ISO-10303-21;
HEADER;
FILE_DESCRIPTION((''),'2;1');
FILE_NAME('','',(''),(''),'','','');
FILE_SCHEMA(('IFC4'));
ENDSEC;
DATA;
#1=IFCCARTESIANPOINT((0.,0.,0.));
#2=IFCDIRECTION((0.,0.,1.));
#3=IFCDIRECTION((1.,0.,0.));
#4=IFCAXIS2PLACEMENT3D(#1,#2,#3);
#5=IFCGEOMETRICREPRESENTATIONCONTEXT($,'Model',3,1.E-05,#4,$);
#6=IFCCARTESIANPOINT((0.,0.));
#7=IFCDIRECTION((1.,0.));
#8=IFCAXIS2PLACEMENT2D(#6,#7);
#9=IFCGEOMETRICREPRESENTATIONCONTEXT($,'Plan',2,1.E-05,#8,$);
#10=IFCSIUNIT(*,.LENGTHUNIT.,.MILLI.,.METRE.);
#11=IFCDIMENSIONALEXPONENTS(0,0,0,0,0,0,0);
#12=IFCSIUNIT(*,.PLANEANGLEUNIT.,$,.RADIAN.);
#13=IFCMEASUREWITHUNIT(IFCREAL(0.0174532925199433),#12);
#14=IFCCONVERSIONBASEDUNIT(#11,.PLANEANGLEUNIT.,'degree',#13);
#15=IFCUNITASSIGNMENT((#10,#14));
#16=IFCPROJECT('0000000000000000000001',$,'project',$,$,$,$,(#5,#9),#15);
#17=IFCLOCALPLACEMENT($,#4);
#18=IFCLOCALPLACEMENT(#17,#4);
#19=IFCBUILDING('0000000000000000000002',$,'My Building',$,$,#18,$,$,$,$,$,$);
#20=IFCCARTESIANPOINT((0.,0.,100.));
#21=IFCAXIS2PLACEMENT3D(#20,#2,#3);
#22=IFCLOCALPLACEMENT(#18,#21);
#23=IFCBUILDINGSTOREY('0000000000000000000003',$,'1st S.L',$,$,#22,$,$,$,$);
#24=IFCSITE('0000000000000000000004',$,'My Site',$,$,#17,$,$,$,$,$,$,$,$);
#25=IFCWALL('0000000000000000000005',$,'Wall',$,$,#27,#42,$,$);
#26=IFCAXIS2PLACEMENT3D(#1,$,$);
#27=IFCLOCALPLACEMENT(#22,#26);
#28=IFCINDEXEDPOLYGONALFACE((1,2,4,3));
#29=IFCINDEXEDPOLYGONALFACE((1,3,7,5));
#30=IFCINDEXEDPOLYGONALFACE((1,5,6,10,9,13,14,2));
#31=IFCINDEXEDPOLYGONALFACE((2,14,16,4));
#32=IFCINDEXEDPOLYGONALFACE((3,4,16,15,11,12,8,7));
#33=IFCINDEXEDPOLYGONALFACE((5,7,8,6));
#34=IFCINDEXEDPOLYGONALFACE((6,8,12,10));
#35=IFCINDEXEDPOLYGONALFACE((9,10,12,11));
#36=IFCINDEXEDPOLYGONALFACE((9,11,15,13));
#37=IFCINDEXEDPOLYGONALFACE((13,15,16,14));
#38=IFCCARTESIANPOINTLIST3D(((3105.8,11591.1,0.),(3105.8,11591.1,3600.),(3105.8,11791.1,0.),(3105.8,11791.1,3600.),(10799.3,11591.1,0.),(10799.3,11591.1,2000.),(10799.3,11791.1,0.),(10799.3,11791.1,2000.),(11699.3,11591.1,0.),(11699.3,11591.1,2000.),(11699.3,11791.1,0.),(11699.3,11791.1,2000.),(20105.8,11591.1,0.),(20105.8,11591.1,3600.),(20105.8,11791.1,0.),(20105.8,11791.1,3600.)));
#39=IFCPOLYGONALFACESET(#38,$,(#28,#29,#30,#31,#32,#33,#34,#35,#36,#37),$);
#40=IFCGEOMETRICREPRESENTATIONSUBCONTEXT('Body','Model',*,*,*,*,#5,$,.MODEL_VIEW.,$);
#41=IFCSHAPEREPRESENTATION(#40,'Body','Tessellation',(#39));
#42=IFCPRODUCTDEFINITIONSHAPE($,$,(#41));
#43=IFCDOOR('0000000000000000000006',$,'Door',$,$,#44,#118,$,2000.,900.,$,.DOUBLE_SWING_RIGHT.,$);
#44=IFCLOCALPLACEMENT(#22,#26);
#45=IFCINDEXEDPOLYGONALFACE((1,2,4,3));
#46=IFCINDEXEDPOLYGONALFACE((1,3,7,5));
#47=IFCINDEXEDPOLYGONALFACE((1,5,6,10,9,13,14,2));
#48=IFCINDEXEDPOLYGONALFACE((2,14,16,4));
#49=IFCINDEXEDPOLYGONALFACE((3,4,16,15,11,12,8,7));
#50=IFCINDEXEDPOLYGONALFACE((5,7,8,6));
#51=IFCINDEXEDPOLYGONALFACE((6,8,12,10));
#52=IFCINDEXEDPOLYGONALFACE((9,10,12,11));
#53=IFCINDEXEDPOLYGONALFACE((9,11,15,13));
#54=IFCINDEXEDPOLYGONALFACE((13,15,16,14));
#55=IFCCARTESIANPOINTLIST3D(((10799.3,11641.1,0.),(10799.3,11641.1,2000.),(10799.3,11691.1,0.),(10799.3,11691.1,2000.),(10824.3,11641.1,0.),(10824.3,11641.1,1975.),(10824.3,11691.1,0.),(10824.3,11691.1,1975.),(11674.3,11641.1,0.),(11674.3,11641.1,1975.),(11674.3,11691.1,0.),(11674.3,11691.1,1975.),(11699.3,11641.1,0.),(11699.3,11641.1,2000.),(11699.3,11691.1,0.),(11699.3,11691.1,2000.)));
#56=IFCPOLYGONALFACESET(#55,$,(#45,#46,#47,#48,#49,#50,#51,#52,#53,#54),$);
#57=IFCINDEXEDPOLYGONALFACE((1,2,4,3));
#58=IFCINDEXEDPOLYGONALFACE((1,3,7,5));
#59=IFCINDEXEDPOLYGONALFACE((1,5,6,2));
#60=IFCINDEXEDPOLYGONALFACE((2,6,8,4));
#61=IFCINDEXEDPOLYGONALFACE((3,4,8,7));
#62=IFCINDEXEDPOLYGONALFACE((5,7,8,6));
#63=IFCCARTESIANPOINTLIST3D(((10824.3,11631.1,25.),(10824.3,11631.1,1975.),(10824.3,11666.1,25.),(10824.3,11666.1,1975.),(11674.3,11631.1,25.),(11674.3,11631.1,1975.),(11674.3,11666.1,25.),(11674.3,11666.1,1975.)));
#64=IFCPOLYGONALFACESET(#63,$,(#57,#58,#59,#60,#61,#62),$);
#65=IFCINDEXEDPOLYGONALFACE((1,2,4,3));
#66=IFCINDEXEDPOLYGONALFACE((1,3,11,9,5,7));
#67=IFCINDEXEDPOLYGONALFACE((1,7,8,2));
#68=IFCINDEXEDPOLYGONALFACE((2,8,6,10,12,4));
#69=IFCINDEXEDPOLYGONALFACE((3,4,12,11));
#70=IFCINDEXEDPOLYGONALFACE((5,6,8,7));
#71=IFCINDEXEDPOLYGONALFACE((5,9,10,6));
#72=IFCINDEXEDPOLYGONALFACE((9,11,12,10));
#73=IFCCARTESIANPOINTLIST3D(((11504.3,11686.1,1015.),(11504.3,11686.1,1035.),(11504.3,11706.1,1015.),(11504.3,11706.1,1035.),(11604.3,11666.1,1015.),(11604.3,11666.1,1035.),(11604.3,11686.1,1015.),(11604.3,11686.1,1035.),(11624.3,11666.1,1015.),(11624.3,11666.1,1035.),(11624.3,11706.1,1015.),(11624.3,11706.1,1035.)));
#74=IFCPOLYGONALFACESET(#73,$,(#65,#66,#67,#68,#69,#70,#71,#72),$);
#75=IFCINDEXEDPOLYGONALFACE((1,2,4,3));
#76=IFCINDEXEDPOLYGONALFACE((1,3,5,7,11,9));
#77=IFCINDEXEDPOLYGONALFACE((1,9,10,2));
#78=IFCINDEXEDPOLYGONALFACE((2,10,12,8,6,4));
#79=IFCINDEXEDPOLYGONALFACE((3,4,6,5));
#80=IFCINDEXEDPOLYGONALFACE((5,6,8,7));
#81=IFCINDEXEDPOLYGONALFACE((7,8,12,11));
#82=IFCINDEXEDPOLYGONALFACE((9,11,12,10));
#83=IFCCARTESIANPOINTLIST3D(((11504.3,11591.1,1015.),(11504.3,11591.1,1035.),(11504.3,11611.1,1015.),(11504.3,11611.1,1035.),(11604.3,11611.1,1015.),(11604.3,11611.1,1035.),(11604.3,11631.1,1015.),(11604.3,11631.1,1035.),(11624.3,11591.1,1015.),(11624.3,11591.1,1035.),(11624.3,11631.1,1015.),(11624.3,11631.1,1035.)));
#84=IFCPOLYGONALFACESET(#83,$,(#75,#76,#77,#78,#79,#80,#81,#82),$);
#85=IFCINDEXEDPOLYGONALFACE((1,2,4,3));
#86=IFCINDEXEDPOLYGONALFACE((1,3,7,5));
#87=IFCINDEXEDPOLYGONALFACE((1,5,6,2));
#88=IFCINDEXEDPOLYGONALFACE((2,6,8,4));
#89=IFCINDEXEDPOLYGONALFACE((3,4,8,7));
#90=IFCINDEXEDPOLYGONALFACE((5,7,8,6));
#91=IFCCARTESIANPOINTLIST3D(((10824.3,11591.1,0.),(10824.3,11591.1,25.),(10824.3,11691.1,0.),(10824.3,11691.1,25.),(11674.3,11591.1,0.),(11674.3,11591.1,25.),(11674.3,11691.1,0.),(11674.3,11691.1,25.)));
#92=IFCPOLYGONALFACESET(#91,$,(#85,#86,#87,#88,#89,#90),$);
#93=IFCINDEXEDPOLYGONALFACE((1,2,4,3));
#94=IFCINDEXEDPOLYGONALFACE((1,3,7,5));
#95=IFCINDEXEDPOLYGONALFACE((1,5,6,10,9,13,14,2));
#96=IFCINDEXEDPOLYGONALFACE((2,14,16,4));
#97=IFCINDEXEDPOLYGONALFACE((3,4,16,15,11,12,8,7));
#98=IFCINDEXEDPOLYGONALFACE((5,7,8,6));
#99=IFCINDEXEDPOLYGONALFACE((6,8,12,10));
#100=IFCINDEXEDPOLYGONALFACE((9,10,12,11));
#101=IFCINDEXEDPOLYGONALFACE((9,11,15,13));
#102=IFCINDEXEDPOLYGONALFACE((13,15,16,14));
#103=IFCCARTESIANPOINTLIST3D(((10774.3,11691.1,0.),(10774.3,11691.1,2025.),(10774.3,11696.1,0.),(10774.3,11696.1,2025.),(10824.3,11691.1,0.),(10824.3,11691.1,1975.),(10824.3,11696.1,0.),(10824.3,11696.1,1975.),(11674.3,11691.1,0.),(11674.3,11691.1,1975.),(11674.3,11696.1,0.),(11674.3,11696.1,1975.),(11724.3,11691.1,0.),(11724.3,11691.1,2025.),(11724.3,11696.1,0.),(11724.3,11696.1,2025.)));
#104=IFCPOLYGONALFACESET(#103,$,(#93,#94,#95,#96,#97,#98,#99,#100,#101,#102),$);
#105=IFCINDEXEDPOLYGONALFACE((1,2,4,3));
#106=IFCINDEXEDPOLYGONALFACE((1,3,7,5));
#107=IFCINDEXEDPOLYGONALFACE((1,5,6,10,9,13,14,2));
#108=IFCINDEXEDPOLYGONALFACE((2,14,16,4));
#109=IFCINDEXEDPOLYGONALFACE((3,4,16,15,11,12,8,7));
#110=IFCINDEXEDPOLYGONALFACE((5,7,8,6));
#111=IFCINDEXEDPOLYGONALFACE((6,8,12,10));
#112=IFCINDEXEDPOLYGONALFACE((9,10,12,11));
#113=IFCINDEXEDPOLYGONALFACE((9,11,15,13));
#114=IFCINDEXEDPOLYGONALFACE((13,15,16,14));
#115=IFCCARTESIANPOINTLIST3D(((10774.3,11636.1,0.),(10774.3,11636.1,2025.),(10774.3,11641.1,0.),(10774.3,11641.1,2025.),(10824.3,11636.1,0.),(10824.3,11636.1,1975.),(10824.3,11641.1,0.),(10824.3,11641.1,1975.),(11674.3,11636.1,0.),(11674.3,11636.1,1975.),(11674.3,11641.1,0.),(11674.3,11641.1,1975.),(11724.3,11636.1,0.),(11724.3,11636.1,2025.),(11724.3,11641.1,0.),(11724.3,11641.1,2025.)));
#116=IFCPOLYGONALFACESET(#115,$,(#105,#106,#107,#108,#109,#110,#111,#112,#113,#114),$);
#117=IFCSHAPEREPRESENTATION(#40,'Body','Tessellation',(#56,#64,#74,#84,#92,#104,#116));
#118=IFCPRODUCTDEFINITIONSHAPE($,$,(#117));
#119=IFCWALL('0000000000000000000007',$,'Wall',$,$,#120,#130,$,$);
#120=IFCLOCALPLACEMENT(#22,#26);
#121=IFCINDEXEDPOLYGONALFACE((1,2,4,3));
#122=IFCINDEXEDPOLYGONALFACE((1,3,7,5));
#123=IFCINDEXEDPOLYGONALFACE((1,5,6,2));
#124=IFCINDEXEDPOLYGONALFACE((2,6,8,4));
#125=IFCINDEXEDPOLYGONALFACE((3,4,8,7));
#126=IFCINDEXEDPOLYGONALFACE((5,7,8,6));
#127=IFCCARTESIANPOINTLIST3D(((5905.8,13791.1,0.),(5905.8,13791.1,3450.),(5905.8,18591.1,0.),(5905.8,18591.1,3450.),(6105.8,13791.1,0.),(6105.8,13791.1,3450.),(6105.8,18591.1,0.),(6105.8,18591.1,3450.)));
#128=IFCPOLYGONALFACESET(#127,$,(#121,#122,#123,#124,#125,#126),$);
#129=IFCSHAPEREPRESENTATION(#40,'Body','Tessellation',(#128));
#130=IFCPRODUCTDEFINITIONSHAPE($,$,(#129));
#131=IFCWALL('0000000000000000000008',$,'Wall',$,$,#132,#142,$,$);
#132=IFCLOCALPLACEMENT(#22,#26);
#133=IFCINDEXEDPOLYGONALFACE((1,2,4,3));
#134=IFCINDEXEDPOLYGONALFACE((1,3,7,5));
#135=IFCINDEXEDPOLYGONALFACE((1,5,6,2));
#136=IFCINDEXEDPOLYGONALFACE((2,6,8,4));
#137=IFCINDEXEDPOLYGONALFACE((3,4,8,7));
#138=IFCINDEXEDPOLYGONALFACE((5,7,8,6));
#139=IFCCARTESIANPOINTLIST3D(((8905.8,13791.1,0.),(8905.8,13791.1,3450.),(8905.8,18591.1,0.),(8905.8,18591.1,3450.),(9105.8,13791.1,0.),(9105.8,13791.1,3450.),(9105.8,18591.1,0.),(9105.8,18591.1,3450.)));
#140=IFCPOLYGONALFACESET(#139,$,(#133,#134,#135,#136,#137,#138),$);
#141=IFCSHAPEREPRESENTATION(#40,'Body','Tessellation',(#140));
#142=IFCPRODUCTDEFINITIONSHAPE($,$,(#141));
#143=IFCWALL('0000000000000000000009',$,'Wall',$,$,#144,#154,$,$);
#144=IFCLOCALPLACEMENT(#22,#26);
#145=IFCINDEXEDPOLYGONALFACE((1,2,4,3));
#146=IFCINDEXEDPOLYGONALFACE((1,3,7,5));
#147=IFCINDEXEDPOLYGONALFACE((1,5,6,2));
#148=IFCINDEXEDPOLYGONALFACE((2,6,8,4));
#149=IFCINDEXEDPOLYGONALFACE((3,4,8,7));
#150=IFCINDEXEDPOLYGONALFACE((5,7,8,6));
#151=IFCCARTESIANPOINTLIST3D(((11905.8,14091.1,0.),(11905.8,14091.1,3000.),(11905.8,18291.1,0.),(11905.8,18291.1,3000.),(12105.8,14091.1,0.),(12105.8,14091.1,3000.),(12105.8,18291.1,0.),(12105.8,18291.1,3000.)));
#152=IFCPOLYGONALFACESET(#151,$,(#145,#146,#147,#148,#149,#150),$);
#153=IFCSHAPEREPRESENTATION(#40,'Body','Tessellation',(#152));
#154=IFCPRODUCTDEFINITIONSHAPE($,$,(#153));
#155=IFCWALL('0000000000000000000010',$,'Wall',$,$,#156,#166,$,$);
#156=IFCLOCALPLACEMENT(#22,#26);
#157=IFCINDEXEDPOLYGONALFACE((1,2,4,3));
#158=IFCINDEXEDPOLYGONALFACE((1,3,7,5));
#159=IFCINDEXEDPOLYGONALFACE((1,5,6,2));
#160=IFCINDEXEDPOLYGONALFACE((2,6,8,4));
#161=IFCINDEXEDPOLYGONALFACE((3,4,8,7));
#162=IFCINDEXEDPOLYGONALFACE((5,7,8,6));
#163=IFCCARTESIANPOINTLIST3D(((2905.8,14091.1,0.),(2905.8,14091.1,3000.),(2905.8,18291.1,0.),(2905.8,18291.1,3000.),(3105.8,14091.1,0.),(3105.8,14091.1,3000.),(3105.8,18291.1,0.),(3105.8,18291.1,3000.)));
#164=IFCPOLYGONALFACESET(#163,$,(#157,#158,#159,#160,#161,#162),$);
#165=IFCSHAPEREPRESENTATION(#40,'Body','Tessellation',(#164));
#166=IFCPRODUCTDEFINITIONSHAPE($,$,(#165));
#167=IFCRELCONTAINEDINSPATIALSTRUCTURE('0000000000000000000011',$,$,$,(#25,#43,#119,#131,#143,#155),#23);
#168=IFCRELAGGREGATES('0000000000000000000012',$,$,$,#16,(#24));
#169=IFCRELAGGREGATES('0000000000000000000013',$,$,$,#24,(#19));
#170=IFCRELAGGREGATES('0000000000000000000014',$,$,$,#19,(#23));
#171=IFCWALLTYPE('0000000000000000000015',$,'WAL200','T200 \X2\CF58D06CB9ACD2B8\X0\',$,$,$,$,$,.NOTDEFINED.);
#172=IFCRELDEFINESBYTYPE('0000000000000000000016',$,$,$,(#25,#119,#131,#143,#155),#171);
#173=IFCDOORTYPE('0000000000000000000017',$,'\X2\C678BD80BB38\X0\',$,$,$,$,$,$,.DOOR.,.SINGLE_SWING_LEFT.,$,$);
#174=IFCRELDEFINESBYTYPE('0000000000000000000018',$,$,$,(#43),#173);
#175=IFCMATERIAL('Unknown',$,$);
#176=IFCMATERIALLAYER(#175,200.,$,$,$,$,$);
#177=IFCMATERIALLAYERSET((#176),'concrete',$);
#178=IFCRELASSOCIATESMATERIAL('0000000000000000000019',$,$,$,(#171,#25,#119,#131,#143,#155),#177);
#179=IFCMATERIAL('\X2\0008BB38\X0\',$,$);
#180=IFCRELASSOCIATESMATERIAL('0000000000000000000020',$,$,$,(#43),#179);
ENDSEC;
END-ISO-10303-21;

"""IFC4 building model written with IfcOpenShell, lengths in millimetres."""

from ifc_helpers import new_model, entity, si_unit, converted_unit, frame, origin_with_axes, origin_2d_with_axis, place, context, subcontext, project, spatial, line, indexed_curve, outline, extrude, clip, halfspace, shape, source, transform, mapped, material, layer, layer_set, layer_usage, type_object, type_shapes, element, fill, save


model = new_model("IFC4")

# Units and contexts
model_context = context("Model", 3, precision=1e-05, world=origin_with_axes())
plan_context = context("Plan", 2, precision=1e-05, world=origin_2d_with_axis())
body_context_1 = subcontext(model_context, "Body", "Model", "MODEL_VIEW")
body_context_2 = subcontext(plan_context, "Body", "Plan", "PLAN_VIEW")
ifc_project = project(units=[si_unit("LENGTHUNIT", "METRE", prefix="MILLI"), converted_unit("PLANEANGLEUNIT", "degree", entity("IfcReal", 0.0174532925199433), si_unit("PLANEANGLEUNIT", "RADIAN"), dimensions=[0, 0, 0, 0, 0, 0, 0])], contexts=[model_context, plan_context])

# Site, building, storey
site_placement = place(None, origin_with_axes())
site = spatial("IfcSite", under=ifc_project, at=site_placement, Name="My Site")
building_placement = place(site_placement, origin_with_axes())
building = spatial("IfcBuilding", under=site, at=building_placement, Name="My Building")
storey_placement = place(building_placement, frame((0.0, 0.0, 100.0), z_axis=(0.0, 0.0, 1.0), x_axis=(1.0, 0.0, 0.0)))
storey = spatial("IfcBuildingStorey", under=building, at=storey_placement, Name="1st S.L")

# Shared definitions
ifc_material_1 = material(Name="Unknown")

# Shared definitions
ifc_layer_1 = layer(ifc_material_1, 200.0)
ifc_layer_set_1 = layer_set([ifc_layer_1], Name="concrete")
wall_type = type_object("IfcWallType", Name="WAL200", Description="T200 콘크리트", PredefinedType="NOTDEFINED", material=ifc_layer_set_1)

# Wall, opening, door
ifc_layer_usage_1 = layer_usage(ifc_layer_set_1, "AXIS2", "POSITIVE", 0.0)
wall_1_placement = place(storey_placement, frame((3105.8, 11591.1, 0.0), z_axis=(0.0, 0.0, 1.0), x_axis=(1.0, 0.0, 0.0)))
wall_1 = element("IfcWall", 1, at=wall_1_placement, inside=storey, type_object=wall_type, material=ifc_layer_usage_1, Name="Wall", context=body_context_1, shape_type="Clipping", body=[
    clip(extrude(outline(indexed_curve([(0.0, 0.0), (0.0, 200.0), (17000.0, 200.0), (17000.0, 0.0), (0.0, 0.0)], self_intersect=False)), origin_with_axes(), (0.0, 0.0, 1.0), 3600.0), halfspace(frame((0.0, 0.0, 3600.0), z_axis=(0.0, 0.0, 1.0), x_axis=(-1.0, 0.0, 0.0)), False)),
])
shared_shape_1 = source(origin_with_axes(), body_context_1, "Body", "SolidModel", [
    extrude(outline(indexed_curve([(0.0, 0.0), (900.0, 0.0), (900.0, 2000.0), (0.0, 2000.0)], segments=[line(1, 2, 3, 4, 1)])), frame((0.0, -600.0, 0.0), z_axis=(0.0, -1.0, 0.0), x_axis=(1.0, 0.0, 0.0)), (0.0, 0.0, -1.0), 1200.0),
])
opening_1_placement = place(wall_1_placement, frame((7693.5, 0.0, 0.0), z_axis=(0.0, 0.0, 1.0), x_axis=(1.0, 0.0, 0.0)))
opening_1 = element("IfcOpeningElement", 2, at=opening_1_placement, cuts=wall_1, PredefinedType="OPENING", context=body_context_1, shape_type="MappedRepresentation", body=[
    mapped(shared_shape_1, transform((0.0, 0.0, 0.0), x_axis=(1.0, 0.0, 0.0), y_axis=(0.0, 1.0, 0.0), z_axis=(0.0, 0.0, 1.0), scale=1.0)),
])
ifc_material_2 = material(Name="\b문")
door_type_1 = type_object("IfcDoorType", Name="외부문", OperationType="SINGLE_SWING_LEFT", PredefinedType="DOOR")
shared_shape_2 = source(origin_with_axes(), body_context_1, "Body", "SolidModel", [
    extrude(outline(indexed_curve([(0.0, 0.0), (0.0, 2000.0), (900.0, 2000.0), (900.0, 0.0), (875.0, 0.0), (875.0, 1975.0), (25.0, 1975.0), (25.0, 0.0)], segments=[line(1, 2, 3, 4, 5, 6, 7, 8, 1)])), frame((0.0, 0.0, 0.0), z_axis=(0.0, -1.0, 0.0), x_axis=(1.0, 0.0, 0.0)), (0.0, 0.0, -1.0), 50.0),
    extrude(outline(indexed_curve([(0.0, 0.0), (850.0, 0.0), (850.0, 35.0), (0.0, 35.0)], segments=[line(1, 2, 3, 4, 1)])), frame((25.0, 25.0, 25.0), z_axis=(0.0, 0.0, 1.0), x_axis=(1.0, 0.0, 0.0)), (0.0, 0.0, 1.0), 1950.0),
    extrude(outline(indexed_curve([(0.0, 0.0), (0.0, -40.0), (120.0, -40.0), (120.0, -20.0), (20.0, -20.0), (20.0, 0.0)], segments=[line(1, 2, 3, 4, 5, 6, 1)])), frame((75.0, 25.0, 1015.0), z_axis=(0.0, 0.0, 1.0), x_axis=(1.0, 0.0, 0.0)), (0.0, 0.0, 1.0), 20.0),
    extrude(outline(indexed_curve([(0.0, 0.0), (0.0, 40.0), (120.0, 40.0), (120.0, 20.0), (20.0, 20.0), (20.0, 0.0)], segments=[line(1, 2, 3, 4, 5, 6, 1)])), frame((75.0, 60.0, 1015.0), z_axis=(0.0, 0.0, 1.0), x_axis=(1.0, 0.0, 0.0)), (0.0, 0.0, 1.0), 20.0),
    extrude(outline(indexed_curve([(0.0, 0.0), (850.0, 0.0), (850.0, 100.0), (0.0, 100.0)], segments=[line(1, 2, 3, 4, 1)])), frame((25.0, 0.0, 0.0), z_axis=(0.0, 0.0, 1.0), x_axis=(1.0, 0.0, 0.0)), (0.0, 0.0, 1.0), 25.0),
    extrude(outline(indexed_curve([(0.0, 0.0), (0.0, 2025.0), (950.0, 2025.0), (950.0, 0.0), (900.0, 0.0), (900.0, 1975.0), (50.0, 1975.0), (50.0, 0.0)], segments=[line(1, 2, 3, 4, 5, 6, 7, 8, 1)])), frame((-25.0, -5.0, 0.0), z_axis=(0.0, -1.0, 0.0), x_axis=(1.0, 0.0, 0.0)), (0.0, 0.0, -1.0), 5.0),
    extrude(outline(indexed_curve([(0.0, 0.0), (0.0, 2025.0), (950.0, 2025.0), (950.0, 0.0), (900.0, 0.0), (900.0, 1975.0), (50.0, 1975.0), (50.0, 0.0)], segments=[line(1, 2, 3, 4, 5, 6, 7, 8, 1)])), frame((-25.0, 50.0, 0.0), z_axis=(0.0, -1.0, 0.0), x_axis=(1.0, 0.0, 0.0)), (0.0, 0.0, -1.0), 5.0),
])
shared_shape_3 = source(origin_with_axes(), body_context_2, "Body", "Curve2D", [
    entity("IfcIndexedPolyCurve", entity("IfcCartesianPointList2D", [[0.0, 0.0], [25.0, 0.0], [25.0, 50.0], [0.0, 50.0]]), [entity("IfcLineIndex", [1, 2, 3, 4, 1])]),
    entity("IfcIndexedPolyCurve", entity("IfcCartesianPointList2D", [[900.0, 0.0], [875.0, 0.0], [875.0, 50.0], [900.0, 50.0]]), [entity("IfcLineIndex", [1, 2, 3, 4, 1])]),
    entity("IfcIndexedPolyCurve", entity("IfcCartesianPointList2D", [[875.0, 50.0], [875.0, -800.0], [840.0, -800.0]])),
    entity("IfcTrimmedCurve", entity("IfcEllipse", entity("IfcAxis2Placement2D", entity("IfcCartesianPoint", [840.0, 50.0]), entity("IfcDirection", [1.0, 0.0])), 815.0, 850.0), [entity("IfcCartesianPoint", [840.0, 900.0])], [entity("IfcCartesianPoint", [840.0, -800.0])], True, "CARTESIAN"),
    entity("IfcIndexedPolyCurve", entity("IfcCartesianPointList2D", [[875.0, 50.0], [840.0, 50.0], [840.0, 900.0], [875.0, 900.0]]), [entity("IfcLineIndex", [1, 2, 3, 4, 1])]),
])
type_shapes(door_type_1, [shared_shape_2, shared_shape_3])
door_1_placement = place(opening_1_placement, frame((900.0, 100.0, 0.0), z_axis=(0.0, 0.0, 1.0), x_axis=(-1.0, 0.0, 0.0)))
door_1 = element("IfcDoor", 3, at=door_1_placement, inside=storey, type_object=door_type_1, material=ifc_material_2, Name="Door", OperationType="DOUBLE_SWING_RIGHT", OverallHeight=2000.0, OverallWidth=900.0, shapes=[
    shape(body_context_1, "Body", "MappedRepresentation", [mapped(shared_shape_2, transform((0.0, 0.0, 0.0), x_axis=(1.0, 0.0, 0.0), y_axis=(0.0, 1.0, 0.0), z_axis=(0.0, 0.0, 1.0), scale=1.0))]),
    shape(body_context_2, "Body", "MappedRepresentation", [mapped(shared_shape_3, transform((0.0, 0.0, 0.0), x_axis=(1.0, 0.0, 0.0), y_axis=(0.0, 1.0, 0.0), z_axis=(0.0, 0.0, 1.0), scale=1.0))]),
])
fill(opening_1, door_1)

# Walls
ifc_layer_usage_2 = layer_usage(ifc_layer_set_1, "AXIS2", "POSITIVE", 0.0)
wall_2_placement = place(storey_placement, frame((6105.8, 13791.1, 0.0), z_axis=(0.0, 0.0, 1.0), x_axis=(0.0, 1.0, 0.0)))
element("IfcWall", 4, at=wall_2_placement, inside=storey, type_object=wall_type, material=ifc_layer_usage_2, Name="Wall", context=body_context_1, shape_type="Clipping", body=[
    clip(extrude(outline(indexed_curve([(0.0, 0.0), (0.0, 200.0), (4800.0, 200.0), (4800.0, 0.0), (0.0, 0.0)], self_intersect=False)), origin_with_axes(), (0.0, 0.0, 1.0), 3450.0), halfspace(frame((0.0, 0.0, 3450.0), z_axis=(0.0, 0.0, 1.0), x_axis=(-1.0, 0.0, 0.0)), False)),
])
ifc_layer_usage_3 = layer_usage(ifc_layer_set_1, "AXIS2", "POSITIVE", 0.0)
wall_3_placement = place(storey_placement, frame((9105.8, 13791.1, 0.0), z_axis=(0.0, 0.0, 1.0), x_axis=(0.0, 1.0, 0.0)))
element("IfcWall", 5, at=wall_3_placement, inside=storey, type_object=wall_type, material=ifc_layer_usage_3, Name="Wall", context=body_context_1, shape_type="Clipping", body=[
    clip(extrude(outline(indexed_curve([(0.0, 0.0), (0.0, 200.0), (4800.0, 200.0), (4800.0, 0.0), (0.0, 0.0)], self_intersect=False)), origin_with_axes(), (0.0, 0.0, 1.0), 3450.0), halfspace(frame((0.0, 0.0, 3450.0), z_axis=(0.0, 0.0, 1.0), x_axis=(-1.0, 0.0, 0.0)), False)),
])
ifc_layer_usage_4 = layer_usage(ifc_layer_set_1, "AXIS2", "POSITIVE", 0.0)
wall_4_placement = place(storey_placement, frame((12105.8, 14091.1, 0.0), z_axis=(0.0, 0.0, 1.0), x_axis=(0.0, 1.0, 0.0)))
element("IfcWall", 6, at=wall_4_placement, inside=storey, type_object=wall_type, material=ifc_layer_usage_4, Name="Wall", context=body_context_1, shape_type="SweptSolid", body=[
    extrude(outline(indexed_curve([(0.0, 0.0), (0.0, 200.0), (4200.0, 200.0), (4200.0, 0.0), (0.0, 0.0)], self_intersect=False)), origin_with_axes(), (0.0, 0.0, 1.0), 3000.0),
])

# Wall
ifc_layer_usage_5 = layer_usage(ifc_layer_set_1, "AXIS2", "POSITIVE", 0.0)
wall_5_placement = place(storey_placement, frame((3105.8, 14091.1, 0.0), z_axis=(0.0, 0.0, 1.0), x_axis=(0.0, 1.0, 0.0)))
element("IfcWall", 7, at=wall_5_placement, inside=storey, type_object=wall_type, material=ifc_layer_usage_5, Name="Wall", context=body_context_1, shape_type="SweptSolid", body=[
    extrude(outline(indexed_curve([(0.0, 0.0), (0.0, 200.0), (4200.0, 200.0), (4200.0, 0.0), (0.0, 0.0)], self_intersect=False)), origin_with_axes(), (0.0, 0.0, 1.0), 3000.0),
])

save(model, "model.ifc")
